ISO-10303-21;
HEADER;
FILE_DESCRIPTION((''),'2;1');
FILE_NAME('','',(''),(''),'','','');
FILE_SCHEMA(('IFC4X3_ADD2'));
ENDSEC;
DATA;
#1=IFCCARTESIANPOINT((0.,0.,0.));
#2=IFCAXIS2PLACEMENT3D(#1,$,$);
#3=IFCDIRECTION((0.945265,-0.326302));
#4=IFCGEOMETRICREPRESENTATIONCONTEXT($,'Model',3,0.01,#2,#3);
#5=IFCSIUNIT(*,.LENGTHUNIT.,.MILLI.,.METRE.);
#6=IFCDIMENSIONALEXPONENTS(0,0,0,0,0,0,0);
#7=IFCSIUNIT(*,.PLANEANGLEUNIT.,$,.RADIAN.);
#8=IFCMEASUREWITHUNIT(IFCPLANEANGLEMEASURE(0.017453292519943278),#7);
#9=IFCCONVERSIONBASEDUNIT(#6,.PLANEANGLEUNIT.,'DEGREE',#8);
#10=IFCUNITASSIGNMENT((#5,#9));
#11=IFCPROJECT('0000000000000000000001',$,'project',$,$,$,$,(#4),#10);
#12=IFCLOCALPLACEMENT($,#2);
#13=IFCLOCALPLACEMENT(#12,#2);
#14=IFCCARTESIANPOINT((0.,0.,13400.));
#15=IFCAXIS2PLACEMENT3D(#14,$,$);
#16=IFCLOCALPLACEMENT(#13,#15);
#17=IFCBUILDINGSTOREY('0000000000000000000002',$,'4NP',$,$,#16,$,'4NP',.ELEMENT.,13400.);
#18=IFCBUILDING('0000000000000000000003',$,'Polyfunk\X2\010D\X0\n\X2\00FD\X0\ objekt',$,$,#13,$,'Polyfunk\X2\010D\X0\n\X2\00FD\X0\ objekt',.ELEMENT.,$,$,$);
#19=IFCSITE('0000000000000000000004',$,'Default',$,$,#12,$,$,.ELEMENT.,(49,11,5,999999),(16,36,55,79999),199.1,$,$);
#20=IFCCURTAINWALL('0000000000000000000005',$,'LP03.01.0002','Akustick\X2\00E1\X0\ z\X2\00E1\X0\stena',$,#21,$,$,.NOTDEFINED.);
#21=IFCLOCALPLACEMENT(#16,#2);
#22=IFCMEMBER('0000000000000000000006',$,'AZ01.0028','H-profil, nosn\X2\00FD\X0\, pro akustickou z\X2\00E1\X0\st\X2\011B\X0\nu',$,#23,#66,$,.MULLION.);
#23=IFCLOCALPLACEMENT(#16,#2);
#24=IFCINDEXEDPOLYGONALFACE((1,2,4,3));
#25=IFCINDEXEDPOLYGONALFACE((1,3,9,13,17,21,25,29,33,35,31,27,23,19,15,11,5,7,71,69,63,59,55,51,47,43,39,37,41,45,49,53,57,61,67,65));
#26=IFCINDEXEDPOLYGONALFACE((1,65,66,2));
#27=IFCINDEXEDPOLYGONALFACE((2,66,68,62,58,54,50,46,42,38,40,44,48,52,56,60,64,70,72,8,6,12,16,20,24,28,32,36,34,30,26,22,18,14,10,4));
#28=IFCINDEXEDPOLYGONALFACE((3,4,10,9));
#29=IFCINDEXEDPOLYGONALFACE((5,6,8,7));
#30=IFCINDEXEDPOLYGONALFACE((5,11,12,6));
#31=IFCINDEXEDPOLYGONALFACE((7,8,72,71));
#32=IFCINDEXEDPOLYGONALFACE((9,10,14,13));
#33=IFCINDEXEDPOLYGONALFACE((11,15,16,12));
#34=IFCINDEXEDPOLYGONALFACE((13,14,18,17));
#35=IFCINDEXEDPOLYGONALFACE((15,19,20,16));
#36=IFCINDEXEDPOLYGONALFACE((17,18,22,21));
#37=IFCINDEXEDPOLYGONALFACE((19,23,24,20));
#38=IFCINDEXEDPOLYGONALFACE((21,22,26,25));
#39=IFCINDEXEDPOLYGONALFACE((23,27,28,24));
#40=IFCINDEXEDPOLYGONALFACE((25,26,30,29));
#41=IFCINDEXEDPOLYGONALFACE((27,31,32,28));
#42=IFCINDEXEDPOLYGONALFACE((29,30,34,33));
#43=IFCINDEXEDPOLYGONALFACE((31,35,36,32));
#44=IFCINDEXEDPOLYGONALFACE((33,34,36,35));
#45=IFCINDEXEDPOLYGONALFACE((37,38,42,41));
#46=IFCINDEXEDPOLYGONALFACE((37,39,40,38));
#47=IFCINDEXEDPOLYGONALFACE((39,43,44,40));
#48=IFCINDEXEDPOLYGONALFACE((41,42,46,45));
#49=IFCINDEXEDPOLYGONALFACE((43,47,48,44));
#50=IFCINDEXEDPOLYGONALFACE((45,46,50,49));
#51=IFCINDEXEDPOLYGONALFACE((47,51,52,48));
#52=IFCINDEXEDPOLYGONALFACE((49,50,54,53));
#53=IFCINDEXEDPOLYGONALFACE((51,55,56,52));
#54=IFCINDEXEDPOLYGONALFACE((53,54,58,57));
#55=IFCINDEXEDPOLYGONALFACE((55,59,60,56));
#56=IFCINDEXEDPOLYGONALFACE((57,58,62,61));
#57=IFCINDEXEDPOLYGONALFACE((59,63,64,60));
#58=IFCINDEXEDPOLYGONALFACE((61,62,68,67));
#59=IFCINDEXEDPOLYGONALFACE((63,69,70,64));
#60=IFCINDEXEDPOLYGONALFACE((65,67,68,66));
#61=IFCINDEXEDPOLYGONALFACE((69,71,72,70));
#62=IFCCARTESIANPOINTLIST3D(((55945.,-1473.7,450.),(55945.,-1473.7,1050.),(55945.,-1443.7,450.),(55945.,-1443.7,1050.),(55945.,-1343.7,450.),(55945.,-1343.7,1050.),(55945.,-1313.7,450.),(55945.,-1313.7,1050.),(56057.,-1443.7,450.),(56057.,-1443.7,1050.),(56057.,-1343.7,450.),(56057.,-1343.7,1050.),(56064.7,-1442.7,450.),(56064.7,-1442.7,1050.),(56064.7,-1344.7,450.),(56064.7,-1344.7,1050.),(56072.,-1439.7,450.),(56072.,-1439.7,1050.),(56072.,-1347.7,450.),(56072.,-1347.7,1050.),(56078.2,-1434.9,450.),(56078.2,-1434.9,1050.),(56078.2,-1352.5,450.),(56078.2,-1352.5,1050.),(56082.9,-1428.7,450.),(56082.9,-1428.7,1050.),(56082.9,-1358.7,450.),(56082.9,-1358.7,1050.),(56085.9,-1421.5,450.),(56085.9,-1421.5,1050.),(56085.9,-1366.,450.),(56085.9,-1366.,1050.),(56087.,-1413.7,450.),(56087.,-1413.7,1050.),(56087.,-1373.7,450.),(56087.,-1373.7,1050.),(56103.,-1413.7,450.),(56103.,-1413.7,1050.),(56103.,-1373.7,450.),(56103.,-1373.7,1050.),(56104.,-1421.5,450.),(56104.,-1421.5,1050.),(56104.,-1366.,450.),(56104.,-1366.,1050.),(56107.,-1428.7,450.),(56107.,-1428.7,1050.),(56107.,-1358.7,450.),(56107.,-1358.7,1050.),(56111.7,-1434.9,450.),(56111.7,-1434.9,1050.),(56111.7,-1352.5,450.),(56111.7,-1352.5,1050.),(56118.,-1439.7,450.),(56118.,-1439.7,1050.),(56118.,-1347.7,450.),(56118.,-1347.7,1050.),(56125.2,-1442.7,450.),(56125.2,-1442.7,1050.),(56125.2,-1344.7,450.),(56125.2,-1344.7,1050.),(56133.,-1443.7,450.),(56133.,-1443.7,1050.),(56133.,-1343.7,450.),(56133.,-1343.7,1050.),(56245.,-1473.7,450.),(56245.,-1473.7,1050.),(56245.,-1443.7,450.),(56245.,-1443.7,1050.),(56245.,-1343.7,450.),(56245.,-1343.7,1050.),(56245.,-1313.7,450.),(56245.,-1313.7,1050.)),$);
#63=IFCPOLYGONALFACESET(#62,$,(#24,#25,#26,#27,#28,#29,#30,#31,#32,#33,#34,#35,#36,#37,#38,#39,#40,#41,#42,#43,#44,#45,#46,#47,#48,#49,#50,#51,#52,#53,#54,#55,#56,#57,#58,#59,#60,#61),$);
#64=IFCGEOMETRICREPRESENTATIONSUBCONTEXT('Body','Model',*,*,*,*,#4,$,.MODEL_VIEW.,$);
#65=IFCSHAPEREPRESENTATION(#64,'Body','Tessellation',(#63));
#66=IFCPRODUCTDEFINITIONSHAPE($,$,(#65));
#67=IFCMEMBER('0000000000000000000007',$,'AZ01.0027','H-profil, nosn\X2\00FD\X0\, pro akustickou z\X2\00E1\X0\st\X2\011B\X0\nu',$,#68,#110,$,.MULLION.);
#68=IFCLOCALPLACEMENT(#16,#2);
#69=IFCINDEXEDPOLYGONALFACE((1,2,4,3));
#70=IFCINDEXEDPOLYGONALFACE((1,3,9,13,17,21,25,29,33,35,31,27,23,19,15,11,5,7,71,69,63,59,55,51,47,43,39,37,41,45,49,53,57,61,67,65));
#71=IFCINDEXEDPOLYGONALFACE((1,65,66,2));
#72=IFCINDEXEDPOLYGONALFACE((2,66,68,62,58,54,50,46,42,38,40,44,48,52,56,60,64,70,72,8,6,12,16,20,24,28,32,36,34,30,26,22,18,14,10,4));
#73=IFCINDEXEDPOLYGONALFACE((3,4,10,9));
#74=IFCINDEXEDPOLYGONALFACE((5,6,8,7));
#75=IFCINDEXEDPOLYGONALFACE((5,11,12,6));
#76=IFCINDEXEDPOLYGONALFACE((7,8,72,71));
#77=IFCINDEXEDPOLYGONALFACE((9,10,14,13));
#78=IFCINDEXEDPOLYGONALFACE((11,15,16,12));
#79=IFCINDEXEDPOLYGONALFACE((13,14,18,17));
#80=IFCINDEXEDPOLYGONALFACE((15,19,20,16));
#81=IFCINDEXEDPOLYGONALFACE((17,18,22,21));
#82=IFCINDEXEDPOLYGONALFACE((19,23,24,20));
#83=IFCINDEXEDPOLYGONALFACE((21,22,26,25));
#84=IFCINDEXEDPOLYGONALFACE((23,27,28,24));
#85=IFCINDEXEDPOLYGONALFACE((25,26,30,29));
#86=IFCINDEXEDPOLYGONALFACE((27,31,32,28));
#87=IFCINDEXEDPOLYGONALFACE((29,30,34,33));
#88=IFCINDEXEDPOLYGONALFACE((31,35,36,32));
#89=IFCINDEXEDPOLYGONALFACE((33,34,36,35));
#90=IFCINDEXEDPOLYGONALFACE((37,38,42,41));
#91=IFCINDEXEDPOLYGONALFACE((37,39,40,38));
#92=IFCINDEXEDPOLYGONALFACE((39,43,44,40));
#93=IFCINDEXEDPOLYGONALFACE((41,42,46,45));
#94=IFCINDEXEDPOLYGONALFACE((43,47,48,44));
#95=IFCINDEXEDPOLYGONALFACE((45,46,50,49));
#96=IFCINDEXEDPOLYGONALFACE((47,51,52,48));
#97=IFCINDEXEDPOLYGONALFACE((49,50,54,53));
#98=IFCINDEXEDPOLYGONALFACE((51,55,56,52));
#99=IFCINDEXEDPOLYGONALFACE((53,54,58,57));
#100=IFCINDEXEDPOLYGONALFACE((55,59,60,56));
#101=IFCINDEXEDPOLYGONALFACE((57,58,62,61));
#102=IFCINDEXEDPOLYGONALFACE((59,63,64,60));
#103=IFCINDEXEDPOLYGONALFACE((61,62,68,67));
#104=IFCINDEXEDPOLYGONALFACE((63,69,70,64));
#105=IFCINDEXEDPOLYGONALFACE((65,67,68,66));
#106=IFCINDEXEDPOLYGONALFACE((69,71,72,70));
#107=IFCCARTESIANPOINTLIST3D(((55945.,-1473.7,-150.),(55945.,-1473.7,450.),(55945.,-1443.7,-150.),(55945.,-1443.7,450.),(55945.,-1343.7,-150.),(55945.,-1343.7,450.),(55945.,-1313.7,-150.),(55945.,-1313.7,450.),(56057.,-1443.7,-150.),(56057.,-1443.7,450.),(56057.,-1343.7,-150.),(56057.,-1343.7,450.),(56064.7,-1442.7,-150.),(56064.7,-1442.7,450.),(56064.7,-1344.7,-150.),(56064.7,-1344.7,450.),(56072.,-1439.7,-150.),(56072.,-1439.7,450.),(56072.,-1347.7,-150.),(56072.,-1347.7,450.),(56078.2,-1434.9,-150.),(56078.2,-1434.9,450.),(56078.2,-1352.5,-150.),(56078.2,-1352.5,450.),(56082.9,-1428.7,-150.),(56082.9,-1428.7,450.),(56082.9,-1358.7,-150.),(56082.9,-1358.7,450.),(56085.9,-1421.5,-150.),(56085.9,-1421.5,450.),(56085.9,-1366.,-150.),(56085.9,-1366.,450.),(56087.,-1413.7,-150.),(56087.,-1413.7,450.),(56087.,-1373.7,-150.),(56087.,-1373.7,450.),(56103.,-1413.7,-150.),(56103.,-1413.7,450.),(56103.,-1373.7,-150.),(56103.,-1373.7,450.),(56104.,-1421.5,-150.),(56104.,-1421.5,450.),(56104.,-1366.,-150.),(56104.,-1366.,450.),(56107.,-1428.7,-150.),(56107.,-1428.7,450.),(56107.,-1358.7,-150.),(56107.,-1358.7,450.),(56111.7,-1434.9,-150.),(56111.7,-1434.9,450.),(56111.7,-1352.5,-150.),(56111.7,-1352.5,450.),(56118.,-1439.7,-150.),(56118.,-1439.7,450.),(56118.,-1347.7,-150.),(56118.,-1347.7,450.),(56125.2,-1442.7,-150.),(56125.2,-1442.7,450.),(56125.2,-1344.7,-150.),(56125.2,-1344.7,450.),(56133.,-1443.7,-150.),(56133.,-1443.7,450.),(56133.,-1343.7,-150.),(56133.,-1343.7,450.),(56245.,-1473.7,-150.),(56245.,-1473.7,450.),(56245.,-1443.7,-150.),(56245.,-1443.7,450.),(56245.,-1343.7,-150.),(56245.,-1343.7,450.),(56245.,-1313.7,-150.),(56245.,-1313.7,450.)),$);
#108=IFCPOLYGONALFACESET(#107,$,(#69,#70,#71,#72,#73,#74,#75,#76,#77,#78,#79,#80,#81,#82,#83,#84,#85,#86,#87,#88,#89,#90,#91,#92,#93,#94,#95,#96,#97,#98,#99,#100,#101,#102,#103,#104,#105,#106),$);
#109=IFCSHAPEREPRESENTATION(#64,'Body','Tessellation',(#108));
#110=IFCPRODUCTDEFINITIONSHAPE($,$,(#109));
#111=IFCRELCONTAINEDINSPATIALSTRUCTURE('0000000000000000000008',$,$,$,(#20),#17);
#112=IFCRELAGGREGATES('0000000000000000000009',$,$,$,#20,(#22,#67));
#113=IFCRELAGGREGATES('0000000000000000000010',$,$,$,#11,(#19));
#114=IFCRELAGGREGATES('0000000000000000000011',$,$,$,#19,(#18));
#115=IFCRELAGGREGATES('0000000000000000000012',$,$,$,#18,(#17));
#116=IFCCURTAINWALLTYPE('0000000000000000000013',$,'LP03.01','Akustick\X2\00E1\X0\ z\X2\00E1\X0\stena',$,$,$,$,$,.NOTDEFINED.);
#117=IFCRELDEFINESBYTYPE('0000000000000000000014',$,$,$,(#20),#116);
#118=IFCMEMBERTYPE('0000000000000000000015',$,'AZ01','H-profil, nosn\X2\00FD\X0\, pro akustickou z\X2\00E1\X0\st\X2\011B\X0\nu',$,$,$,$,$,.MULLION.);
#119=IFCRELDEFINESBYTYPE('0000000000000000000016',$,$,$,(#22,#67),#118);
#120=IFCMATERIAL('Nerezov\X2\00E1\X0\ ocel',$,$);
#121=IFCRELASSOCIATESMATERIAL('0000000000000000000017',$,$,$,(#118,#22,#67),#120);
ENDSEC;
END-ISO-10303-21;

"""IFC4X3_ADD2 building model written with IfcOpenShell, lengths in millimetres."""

from ifc_helpers import new_model, entity, si_unit, converted_unit, direction, frame, frame_2d, origin, place, context, subcontext, project, spatial, polyline, circle_curve, parameter, trimmed, segment, composite_curve, outline, extrude, source, transform, mapped, material, material_profile, profile_set, profile_usage, type_object, element, aggregate, save


model = new_model("IFC4X3_ADD2")

# Units and contexts
model_context = context("Model", 3, precision=0.01, world=origin(), true_north=direction((0.945265, -0.326302)))
body_context = subcontext(model_context, "Body", "Model", "MODEL_VIEW")
ifc_project = project(units=[si_unit("LENGTHUNIT", "METRE", prefix="MILLI"), converted_unit("PLANEANGLEUNIT", "DEGREE", entity("IfcPlaneAngleMeasure", 0.017453292519943278), si_unit("PLANEANGLEUNIT", "RADIAN"), dimensions=[0, 0, 0, 0, 0, 0, 0])], contexts=[model_context])

# Site, building, storey
site_placement = place(None, origin())
site = spatial("IfcSite", under=ifc_project, at=site_placement, Name="Default", CompositionType="ELEMENT", RefLatitude=(49, 11, 5, 999999), RefLongitude=(16, 36, 55, 79999), RefElevation=199.1)
building_placement = place(site_placement, origin())
building = spatial("IfcBuilding", under=site, at=building_placement, Name="Polyfunkčný objekt", LongName="Polyfunkčný objekt", CompositionType="ELEMENT")
storey_placement = place(building_placement, frame((0.0, 0.0, 13400.0)))
storey = spatial("IfcBuildingStorey", under=building, at=storey_placement, Name="4NP", LongName="4NP", CompositionType="ELEMENT", Elevation=13400.0)

# Curtain wall, members
curtain_wall_type_1 = type_object("IfcCurtainWallType", Name="LP03.01", Description="Akustická zástena", PredefinedType="NOTDEFINED")
curtain_wall_1_placement = place(storey_placement, frame((0.0, 0.0, -13400.0)))
curtain_wall_1 = element("IfcCurtainWall", 1, at=curtain_wall_1_placement, inside=storey, type_object=curtain_wall_type_1, Name="LP03.01.0002", Description="Akustická zástena", PredefinedType="NOTDEFINED")
ifc_material_1 = material(Name="Nerezová ocel")
ifc_material_profile = material_profile(ifc_material_1, outline(composite_curve([segment(polyline([(50.0, -150.0), (80.0, -150.0)]), True, "CONTINUOUS"), segment(polyline([(80.0, -150.0), (80.0, 150.0)]), True, "CONTINUOUS"), segment(polyline([(80.0, 150.0), (50.0, 150.0)]), True, "CONTINUOUS"), segment(polyline([(50.0, 150.0), (50.0, 38.0)]), True, "CONTINUOUS"), segment(trimmed(circle_curve(frame_2d((20.0, 38.0), x_axis=(0.0, 1.0)), 30.0), [parameter(180.0)], [parameter(270.0)], True, "PARAMETER"), False, "CONTINUOUS"), segment(polyline([(20.0, 8.0), (-20.0, 8.0)]), True, "CONTINUOUS"), segment(trimmed(circle_curve(frame_2d((-20.0, 38.0), x_axis=(0.0, 1.0)), 30.0), [parameter(90.0)], [parameter(180.0)], True, "PARAMETER"), False, "CONTINUOUS"), segment(polyline([(-50.0, 38.0), (-50.0, 150.0)]), True, "CONTINUOUS"), segment(polyline([(-50.0, 150.0), (-80.0, 150.0)]), True, "CONTINUOUS"), segment(polyline([(-80.0, 150.0), (-80.0, -150.0)]), True, "CONTINUOUS"), segment(polyline([(-80.0, -150.0), (-50.0, -150.0)]), True, "CONTINUOUS"), segment(polyline([(-50.0, -150.0), (-50.0, -38.0)]), True, "CONTINUOUS"), segment(trimmed(circle_curve(frame_2d((-20.0, -38.0), x_axis=(0.0, 1.0)), 30.0), [parameter(0.0)], [parameter(90.0)], True, "PARAMETER"), False, "CONTINUOUS"), segment(polyline([(-20.0, -8.0), (20.0, -8.0)]), True, "CONTINUOUS"), segment(trimmed(circle_curve(frame_2d((20.0, -38.0), x_axis=(0.0, 1.0)), 30.0), [parameter(270.0)], [parameter(0.0)], True, "PARAMETER"), False, "CONTINUOUS"), segment(polyline([(50.0, -38.0), (50.0, -150.0)]), True, "CONTINUOUS")], self_intersect=False)), Name="Profil zástena")
ifc_profile_set = profile_set([ifc_material_profile], Name="Profil zástena")
ifc_profile_usage = profile_usage(ifc_profile_set)
member_type = type_object("IfcMemberType", Name="AZ01", Description="H-profil, nosný, pro akustickou zástěnu", PredefinedType="MULLION", material=ifc_profile_set)
shared_shape_1 = source(origin(), body_context, "Body", "SweptSolid", [
    extrude(outline(composite_curve([segment(polyline([(50.0, -150.0), (80.0, -150.0)]), True, "CONTINUOUS"), segment(polyline([(80.0, -150.0), (80.0, 150.0)]), True, "CONTINUOUS"), segment(polyline([(80.0, 150.0), (50.0, 150.0)]), True, "CONTINUOUS"), segment(polyline([(50.0, 150.0), (50.0, 38.0)]), True, "CONTINUOUS"), segment(trimmed(circle_curve(frame_2d((20.0, 38.0), x_axis=(0.0, 1.0)), 30.0), [parameter(180.0)], [parameter(270.0)], True, "PARAMETER"), False, "CONTINUOUS"), segment(polyline([(20.0, 8.0), (-20.0, 8.0)]), True, "CONTINUOUS"), segment(trimmed(circle_curve(frame_2d((-20.0, 38.0), x_axis=(0.0, 1.0)), 30.0), [parameter(90.0)], [parameter(180.0)], True, "PARAMETER"), False, "CONTINUOUS"), segment(polyline([(-50.0, 38.0), (-50.0, 150.0)]), True, "CONTINUOUS"), segment(polyline([(-50.0, 150.0), (-80.0, 150.0)]), True, "CONTINUOUS"), segment(polyline([(-80.0, 150.0), (-80.0, -150.0)]), True, "CONTINUOUS"), segment(polyline([(-80.0, -150.0), (-50.0, -150.0)]), True, "CONTINUOUS"), segment(polyline([(-50.0, -150.0), (-50.0, -38.0)]), True, "CONTINUOUS"), segment(trimmed(circle_curve(frame_2d((-20.0, -38.0), x_axis=(0.0, 1.0)), 30.0), [parameter(0.0)], [parameter(90.0)], True, "PARAMETER"), False, "CONTINUOUS"), segment(polyline([(-20.0, -8.0), (20.0, -8.0)]), True, "CONTINUOUS"), segment(trimmed(circle_curve(frame_2d((20.0, -38.0), x_axis=(0.0, 1.0)), 30.0), [parameter(270.0)], [parameter(0.0)], True, "PARAMETER"), False, "CONTINUOUS"), segment(polyline([(50.0, -38.0), (50.0, -150.0)]), True, "CONTINUOUS")], self_intersect=False)), frame((-150.0, 0.0, -600.0), z_axis=(0.0, 0.0, 1.0), x_axis=(0.0, -1.0, 0.0)), (0.0, 0.0, 1.0), 600.0),
])
member_1_placement = place(curtain_wall_1_placement, frame((56245.0, -1393.7, 13850.0), z_axis=(0.0, 0.0, -1.0), x_axis=(1.0, 0.0, 0.0)))
member_1 = element("IfcMember", 2, at=member_1_placement, type_object=member_type, material=ifc_profile_usage, Name="AZ01.0028", Description="H-profil, nosný, pro akustickou zástěnu", PredefinedType="MULLION", context=body_context, shape_type="MappedRepresentation", body=[
    mapped(shared_shape_1, transform((0.0, 0.0, 0.0), scale=1.0)),
])
shared_shape_2 = source(origin(), body_context, "Body", "SweptSolid", [
    extrude(outline(composite_curve([segment(polyline([(50.0, -150.0), (80.0, -150.0)]), True, "CONTINUOUS"), segment(polyline([(80.0, -150.0), (80.0, 150.0)]), True, "CONTINUOUS"), segment(polyline([(80.0, 150.0), (50.0, 150.0)]), True, "CONTINUOUS"), segment(polyline([(50.0, 150.0), (50.0, 38.0)]), True, "CONTINUOUS"), segment(trimmed(circle_curve(frame_2d((20.0, 38.0), x_axis=(0.0, 1.0)), 30.0), [parameter(180.0)], [parameter(270.0)], True, "PARAMETER"), False, "CONTINUOUS"), segment(polyline([(20.0, 8.0), (-20.0, 8.0)]), True, "CONTINUOUS"), segment(trimmed(circle_curve(frame_2d((-20.0, 38.0), x_axis=(0.0, 1.0)), 30.0), [parameter(90.0)], [parameter(180.0)], True, "PARAMETER"), False, "CONTINUOUS"), segment(polyline([(-50.0, 38.0), (-50.0, 150.0)]), True, "CONTINUOUS"), segment(polyline([(-50.0, 150.0), (-80.0, 150.0)]), True, "CONTINUOUS"), segment(polyline([(-80.0, 150.0), (-80.0, -150.0)]), True, "CONTINUOUS"), segment(polyline([(-80.0, -150.0), (-50.0, -150.0)]), True, "CONTINUOUS"), segment(polyline([(-50.0, -150.0), (-50.0, -38.0)]), True, "CONTINUOUS"), segment(trimmed(circle_curve(frame_2d((-20.0, -38.0), x_axis=(0.0, 1.0)), 30.0), [parameter(0.0)], [parameter(90.0)], True, "PARAMETER"), False, "CONTINUOUS"), segment(polyline([(-20.0, -8.0), (20.0, -8.0)]), True, "CONTINUOUS"), segment(trimmed(circle_curve(frame_2d((20.0, -38.0), x_axis=(0.0, 1.0)), 30.0), [parameter(270.0)], [parameter(0.0)], True, "PARAMETER"), False, "CONTINUOUS"), segment(polyline([(50.0, -38.0), (50.0, -150.0)]), True, "CONTINUOUS")], self_intersect=False)), frame((-150.0, 0.0, -600.0), z_axis=(0.0, 0.0, 1.0), x_axis=(0.0, -1.0, 0.0)), (0.0, 0.0, 1.0), 600.0),
])
member_2_placement = place(curtain_wall_1_placement, frame((56245.0, -1393.7, 13250.0), z_axis=(0.0, 0.0, -1.0), x_axis=(1.0, 0.0, 0.0)))
member_2 = element("IfcMember", 3, at=member_2_placement, type_object=member_type, material=ifc_profile_usage, Name="AZ01.0027", Description="H-profil, nosný, pro akustickou zástěnu", PredefinedType="MULLION", context=body_context, shape_type="MappedRepresentation", body=[
    mapped(shared_shape_2, transform((0.0, 0.0, 0.0), scale=1.0)),
])
aggregate(curtain_wall_1, [member_1, member_2])

save(model, "model.ifc")
